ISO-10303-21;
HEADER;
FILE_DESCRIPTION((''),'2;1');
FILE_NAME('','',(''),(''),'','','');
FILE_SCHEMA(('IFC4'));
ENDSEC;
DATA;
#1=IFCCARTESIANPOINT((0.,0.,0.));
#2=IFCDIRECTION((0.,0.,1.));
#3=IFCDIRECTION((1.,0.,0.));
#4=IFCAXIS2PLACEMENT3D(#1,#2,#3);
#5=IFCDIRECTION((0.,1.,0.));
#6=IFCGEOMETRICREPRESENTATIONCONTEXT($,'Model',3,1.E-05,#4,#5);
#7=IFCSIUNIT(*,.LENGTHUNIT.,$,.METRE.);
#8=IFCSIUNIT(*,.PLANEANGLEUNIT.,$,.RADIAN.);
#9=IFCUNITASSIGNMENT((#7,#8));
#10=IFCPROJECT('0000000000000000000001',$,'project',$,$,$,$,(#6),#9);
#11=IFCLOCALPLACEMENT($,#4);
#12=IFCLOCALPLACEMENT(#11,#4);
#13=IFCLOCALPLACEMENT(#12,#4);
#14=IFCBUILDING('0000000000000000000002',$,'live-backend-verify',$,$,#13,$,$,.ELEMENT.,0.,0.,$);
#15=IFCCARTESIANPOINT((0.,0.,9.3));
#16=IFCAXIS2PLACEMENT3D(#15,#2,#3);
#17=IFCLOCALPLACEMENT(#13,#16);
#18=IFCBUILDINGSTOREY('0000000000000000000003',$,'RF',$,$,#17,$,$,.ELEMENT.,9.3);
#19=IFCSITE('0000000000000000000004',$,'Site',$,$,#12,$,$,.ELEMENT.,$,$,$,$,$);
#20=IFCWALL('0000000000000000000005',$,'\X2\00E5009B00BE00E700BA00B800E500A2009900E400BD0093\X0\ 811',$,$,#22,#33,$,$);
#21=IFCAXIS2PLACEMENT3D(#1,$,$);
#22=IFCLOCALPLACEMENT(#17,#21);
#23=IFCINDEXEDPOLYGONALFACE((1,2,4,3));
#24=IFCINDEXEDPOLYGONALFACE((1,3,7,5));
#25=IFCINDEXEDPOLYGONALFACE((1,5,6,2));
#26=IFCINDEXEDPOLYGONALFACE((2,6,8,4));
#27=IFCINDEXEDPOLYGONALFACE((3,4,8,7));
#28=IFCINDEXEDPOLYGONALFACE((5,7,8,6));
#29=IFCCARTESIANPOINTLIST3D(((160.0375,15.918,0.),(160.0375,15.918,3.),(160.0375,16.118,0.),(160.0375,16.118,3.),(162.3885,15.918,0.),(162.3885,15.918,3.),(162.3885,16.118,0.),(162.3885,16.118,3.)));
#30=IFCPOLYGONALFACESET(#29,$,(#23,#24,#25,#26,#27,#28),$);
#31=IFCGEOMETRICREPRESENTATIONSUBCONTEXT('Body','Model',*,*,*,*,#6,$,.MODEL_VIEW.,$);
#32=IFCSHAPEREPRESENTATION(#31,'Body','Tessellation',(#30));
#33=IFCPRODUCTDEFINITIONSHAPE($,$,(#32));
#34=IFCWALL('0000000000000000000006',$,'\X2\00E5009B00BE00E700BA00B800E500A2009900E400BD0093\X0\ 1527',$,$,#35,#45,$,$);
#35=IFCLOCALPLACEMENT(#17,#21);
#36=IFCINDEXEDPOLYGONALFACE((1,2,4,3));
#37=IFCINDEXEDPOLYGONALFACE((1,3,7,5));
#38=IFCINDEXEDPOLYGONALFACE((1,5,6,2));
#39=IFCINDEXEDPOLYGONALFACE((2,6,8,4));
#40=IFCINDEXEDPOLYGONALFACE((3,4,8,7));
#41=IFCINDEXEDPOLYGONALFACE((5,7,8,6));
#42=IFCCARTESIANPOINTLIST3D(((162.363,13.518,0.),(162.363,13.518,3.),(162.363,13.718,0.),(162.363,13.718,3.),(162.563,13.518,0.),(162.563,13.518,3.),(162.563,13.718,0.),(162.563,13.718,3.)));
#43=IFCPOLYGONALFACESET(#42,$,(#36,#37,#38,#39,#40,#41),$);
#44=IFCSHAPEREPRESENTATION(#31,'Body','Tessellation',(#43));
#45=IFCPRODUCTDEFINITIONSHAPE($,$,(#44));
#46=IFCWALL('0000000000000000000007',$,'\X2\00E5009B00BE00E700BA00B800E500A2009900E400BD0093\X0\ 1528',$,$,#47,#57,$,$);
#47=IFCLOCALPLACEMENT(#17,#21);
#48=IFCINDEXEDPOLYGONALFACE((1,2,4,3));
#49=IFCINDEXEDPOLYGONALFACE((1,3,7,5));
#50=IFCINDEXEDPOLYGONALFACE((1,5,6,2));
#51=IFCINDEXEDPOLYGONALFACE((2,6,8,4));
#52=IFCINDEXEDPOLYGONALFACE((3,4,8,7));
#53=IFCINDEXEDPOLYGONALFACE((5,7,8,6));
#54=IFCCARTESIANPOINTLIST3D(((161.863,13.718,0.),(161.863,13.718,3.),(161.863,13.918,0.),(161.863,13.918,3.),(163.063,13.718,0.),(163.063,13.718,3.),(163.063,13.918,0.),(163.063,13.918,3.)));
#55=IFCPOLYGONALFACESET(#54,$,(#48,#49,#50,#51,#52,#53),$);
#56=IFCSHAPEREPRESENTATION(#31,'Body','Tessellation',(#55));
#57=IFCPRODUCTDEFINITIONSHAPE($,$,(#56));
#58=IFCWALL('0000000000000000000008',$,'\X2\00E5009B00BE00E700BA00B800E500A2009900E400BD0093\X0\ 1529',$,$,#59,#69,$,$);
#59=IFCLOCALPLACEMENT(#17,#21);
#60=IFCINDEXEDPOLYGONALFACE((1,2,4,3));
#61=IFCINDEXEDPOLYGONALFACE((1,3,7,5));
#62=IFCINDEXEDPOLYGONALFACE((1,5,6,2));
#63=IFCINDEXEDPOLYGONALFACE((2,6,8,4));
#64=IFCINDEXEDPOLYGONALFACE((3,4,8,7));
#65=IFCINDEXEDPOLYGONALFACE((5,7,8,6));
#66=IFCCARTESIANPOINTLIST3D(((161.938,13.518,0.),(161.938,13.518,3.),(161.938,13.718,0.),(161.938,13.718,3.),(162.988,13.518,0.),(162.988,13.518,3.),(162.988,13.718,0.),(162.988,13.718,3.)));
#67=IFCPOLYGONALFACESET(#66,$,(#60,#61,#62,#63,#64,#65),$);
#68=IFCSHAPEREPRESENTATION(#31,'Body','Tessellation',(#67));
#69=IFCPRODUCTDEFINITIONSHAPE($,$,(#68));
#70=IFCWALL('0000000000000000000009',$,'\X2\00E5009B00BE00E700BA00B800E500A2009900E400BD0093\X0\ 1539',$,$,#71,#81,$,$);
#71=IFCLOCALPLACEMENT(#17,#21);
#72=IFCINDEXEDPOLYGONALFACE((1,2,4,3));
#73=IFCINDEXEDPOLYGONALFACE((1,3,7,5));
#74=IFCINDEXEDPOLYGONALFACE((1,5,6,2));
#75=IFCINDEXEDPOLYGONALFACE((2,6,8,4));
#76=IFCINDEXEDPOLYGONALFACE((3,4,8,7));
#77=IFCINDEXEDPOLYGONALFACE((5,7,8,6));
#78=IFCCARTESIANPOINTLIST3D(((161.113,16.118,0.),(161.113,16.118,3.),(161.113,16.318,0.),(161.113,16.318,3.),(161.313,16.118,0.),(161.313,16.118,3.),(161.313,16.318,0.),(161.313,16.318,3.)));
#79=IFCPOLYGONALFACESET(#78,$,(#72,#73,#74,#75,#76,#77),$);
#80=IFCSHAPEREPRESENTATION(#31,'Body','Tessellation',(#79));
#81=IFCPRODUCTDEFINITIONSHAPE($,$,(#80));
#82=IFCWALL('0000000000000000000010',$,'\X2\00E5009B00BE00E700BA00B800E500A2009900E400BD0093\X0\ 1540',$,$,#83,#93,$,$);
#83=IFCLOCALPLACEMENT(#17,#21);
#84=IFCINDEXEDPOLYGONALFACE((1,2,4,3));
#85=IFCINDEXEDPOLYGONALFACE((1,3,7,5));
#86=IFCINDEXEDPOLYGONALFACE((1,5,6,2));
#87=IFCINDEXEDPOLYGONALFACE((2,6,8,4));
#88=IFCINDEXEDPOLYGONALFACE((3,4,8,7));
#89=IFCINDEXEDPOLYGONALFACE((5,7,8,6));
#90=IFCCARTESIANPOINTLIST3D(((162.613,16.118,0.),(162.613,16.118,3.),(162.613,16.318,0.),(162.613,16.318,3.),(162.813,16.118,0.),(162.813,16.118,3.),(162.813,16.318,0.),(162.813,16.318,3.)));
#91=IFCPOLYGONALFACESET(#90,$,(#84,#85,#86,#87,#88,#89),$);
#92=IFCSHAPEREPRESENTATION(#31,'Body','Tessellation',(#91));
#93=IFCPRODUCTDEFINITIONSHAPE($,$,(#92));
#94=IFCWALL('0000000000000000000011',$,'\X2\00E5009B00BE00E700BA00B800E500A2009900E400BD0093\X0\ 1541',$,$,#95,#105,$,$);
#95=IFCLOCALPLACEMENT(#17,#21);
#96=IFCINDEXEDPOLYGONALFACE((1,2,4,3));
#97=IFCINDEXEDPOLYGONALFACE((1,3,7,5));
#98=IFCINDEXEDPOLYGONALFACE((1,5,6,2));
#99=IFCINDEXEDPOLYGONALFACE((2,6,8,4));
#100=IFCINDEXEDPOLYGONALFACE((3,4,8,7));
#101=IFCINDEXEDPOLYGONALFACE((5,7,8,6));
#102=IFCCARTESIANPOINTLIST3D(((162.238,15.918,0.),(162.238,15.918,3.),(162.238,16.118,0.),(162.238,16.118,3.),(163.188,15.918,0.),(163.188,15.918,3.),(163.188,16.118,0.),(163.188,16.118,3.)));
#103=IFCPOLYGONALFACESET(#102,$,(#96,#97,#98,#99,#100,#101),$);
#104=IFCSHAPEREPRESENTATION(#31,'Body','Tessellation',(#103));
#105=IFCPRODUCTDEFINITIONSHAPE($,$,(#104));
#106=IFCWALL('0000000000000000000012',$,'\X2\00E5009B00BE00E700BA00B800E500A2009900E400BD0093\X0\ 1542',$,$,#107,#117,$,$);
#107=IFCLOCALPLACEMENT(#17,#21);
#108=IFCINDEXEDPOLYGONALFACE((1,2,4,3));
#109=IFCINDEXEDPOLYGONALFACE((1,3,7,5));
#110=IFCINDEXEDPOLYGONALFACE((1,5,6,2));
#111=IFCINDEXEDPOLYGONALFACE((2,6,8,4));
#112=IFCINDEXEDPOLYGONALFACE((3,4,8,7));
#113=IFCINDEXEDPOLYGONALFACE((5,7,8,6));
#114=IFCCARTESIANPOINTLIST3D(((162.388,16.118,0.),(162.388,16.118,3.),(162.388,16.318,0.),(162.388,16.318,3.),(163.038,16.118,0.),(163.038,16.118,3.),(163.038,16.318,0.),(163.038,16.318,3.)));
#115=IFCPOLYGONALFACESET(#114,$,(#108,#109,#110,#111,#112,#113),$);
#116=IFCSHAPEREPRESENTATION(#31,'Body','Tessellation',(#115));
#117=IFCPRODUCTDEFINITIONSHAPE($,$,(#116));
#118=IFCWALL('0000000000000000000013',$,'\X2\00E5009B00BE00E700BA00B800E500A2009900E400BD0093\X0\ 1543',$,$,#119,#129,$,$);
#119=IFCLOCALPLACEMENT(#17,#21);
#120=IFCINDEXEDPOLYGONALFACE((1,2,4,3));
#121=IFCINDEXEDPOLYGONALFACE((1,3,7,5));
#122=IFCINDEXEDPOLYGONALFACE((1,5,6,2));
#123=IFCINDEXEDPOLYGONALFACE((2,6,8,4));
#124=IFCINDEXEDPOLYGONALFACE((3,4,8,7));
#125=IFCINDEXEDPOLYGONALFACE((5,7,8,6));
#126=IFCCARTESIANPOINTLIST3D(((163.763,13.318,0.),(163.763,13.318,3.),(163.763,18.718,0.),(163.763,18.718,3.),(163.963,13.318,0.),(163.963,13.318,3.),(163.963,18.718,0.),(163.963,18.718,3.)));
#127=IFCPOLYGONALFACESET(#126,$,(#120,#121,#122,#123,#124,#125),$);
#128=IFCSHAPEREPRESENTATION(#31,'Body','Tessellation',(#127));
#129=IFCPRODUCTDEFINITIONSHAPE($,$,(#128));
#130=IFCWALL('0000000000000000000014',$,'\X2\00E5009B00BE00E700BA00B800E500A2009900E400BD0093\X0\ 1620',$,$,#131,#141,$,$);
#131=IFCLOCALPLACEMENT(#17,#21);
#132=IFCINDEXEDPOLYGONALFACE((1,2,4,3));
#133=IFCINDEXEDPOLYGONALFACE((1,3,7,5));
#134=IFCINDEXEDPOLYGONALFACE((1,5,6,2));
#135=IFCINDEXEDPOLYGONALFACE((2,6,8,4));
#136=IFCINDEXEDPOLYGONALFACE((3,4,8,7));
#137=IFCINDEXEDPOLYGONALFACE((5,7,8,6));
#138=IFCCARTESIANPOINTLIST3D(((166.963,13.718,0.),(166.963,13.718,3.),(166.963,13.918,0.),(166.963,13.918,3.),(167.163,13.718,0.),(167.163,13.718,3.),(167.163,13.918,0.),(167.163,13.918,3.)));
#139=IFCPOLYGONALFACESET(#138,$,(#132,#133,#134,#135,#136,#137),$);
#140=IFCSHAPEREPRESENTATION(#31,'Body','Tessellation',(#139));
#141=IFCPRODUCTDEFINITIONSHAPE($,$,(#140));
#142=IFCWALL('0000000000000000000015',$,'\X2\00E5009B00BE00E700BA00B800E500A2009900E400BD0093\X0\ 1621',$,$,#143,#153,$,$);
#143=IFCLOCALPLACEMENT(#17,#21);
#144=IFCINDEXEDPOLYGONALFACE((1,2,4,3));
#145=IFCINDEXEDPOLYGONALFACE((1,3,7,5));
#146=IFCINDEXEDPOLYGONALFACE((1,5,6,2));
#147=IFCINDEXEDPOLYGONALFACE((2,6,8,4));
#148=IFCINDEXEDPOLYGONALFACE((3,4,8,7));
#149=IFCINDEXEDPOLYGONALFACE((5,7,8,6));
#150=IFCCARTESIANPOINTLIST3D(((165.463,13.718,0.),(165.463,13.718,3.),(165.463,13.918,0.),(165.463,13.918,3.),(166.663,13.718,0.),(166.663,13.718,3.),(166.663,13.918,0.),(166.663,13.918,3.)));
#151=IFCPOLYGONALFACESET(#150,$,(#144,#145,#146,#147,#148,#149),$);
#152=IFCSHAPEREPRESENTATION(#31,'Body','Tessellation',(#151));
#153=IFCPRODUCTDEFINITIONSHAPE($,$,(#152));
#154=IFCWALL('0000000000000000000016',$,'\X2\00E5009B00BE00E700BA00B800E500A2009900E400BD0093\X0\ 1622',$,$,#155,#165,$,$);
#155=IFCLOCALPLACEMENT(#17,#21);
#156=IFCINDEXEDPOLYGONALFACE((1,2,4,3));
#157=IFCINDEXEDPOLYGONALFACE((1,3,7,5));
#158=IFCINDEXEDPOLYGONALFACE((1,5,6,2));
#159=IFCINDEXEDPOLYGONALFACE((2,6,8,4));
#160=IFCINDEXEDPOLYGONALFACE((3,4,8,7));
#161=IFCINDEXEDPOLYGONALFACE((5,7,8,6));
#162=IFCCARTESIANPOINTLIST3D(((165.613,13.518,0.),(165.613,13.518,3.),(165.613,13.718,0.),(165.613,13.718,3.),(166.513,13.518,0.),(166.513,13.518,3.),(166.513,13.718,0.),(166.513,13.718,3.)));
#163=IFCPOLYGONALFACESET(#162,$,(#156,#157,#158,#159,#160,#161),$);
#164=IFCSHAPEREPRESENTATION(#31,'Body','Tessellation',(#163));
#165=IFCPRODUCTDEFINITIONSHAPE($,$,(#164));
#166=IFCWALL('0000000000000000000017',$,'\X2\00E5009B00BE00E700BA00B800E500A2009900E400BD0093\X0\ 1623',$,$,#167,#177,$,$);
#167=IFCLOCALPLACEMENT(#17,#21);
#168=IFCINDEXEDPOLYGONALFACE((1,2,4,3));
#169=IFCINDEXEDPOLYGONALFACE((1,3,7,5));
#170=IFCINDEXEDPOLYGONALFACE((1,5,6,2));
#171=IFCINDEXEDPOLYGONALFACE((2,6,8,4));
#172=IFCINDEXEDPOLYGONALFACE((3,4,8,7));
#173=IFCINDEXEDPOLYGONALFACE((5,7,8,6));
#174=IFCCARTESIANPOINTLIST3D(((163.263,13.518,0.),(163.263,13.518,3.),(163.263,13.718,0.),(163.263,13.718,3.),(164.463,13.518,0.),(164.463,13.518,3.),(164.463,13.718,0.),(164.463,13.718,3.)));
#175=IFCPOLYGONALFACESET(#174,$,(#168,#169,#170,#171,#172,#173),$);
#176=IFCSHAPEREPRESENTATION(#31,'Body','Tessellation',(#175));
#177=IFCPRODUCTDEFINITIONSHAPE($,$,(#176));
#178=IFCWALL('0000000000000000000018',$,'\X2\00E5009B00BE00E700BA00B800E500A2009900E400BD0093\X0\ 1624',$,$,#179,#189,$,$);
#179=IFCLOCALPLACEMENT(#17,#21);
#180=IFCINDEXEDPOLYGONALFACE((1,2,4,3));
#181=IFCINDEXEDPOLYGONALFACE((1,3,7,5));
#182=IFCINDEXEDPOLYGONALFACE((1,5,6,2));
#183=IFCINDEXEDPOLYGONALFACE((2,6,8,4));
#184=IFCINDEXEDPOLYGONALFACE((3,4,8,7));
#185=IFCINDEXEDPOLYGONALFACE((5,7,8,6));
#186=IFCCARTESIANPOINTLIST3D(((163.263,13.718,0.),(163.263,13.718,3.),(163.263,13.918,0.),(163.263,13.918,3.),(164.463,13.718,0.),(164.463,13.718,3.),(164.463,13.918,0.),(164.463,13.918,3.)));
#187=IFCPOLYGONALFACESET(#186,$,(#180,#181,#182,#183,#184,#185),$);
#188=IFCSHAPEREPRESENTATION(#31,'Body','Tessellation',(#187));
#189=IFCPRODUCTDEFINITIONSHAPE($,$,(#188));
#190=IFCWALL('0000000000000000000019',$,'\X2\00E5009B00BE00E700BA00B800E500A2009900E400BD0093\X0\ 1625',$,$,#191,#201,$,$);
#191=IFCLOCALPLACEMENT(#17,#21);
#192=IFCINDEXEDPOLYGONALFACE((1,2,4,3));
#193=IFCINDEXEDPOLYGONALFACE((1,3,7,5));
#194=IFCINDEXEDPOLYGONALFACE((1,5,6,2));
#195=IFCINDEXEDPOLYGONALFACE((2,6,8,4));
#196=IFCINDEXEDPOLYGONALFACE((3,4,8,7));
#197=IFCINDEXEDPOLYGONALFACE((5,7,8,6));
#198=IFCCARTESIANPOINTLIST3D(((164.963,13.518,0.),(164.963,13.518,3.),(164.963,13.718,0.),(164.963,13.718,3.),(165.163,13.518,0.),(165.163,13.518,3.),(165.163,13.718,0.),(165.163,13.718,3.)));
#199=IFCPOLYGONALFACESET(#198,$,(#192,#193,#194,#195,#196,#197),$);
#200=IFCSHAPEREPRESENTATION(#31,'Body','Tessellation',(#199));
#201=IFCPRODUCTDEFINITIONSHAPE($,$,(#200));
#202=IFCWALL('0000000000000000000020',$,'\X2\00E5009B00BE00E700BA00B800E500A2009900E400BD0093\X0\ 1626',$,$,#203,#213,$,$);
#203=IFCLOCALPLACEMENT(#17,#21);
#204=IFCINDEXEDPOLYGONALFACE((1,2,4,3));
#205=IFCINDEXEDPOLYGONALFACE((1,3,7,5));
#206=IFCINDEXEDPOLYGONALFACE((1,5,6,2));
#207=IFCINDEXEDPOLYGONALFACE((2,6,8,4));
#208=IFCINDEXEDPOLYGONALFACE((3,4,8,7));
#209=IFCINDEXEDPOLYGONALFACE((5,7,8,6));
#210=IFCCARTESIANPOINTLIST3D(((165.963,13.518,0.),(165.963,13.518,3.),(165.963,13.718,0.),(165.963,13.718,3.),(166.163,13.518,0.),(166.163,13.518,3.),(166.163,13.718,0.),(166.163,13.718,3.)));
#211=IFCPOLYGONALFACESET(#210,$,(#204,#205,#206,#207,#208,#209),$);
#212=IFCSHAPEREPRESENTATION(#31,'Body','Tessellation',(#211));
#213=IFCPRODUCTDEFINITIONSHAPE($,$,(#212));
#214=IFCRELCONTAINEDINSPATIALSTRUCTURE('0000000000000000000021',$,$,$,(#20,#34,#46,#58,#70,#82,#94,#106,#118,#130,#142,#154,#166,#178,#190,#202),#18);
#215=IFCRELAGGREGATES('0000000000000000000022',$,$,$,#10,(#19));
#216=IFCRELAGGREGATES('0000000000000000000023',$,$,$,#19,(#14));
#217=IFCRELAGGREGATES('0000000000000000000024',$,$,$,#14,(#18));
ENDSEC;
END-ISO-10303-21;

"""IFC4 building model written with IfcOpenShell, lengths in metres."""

from ifc_helpers import new_model, si_unit, direction, frame, frame_2d, origin_with_axes, place, context, subcontext, project, spatial, rectangle, extrude, element, save


model = new_model("IFC4")

# Units and contexts
model_context = context("Model", 3, precision=1e-05, world=origin_with_axes(), true_north=direction((0.0, 1.0, 0.0)))
body_context = subcontext(model_context, "Body", "Model", "MODEL_VIEW")
ifc_project = project(units=[si_unit("LENGTHUNIT", "METRE"), si_unit("PLANEANGLEUNIT", "RADIAN")], contexts=[model_context])

# Site, building, storey
placement = place(None, origin_with_axes())
site_placement = place(placement, origin_with_axes())
site = spatial("IfcSite", under=ifc_project, at=site_placement, Name="Site", CompositionType="ELEMENT")
building_placement = place(site_placement, origin_with_axes())
building = spatial("IfcBuilding", under=site, at=building_placement, Name="live-backend-verify", CompositionType="ELEMENT", ElevationOfRefHeight=0.0, ElevationOfTerrain=0.0)
storey_placement = place(building_placement, frame((0.0, 0.0, 9.3), z_axis=(0.0, 0.0, 1.0), x_axis=(1.0, 0.0, 0.0)))
storey = spatial("IfcBuildingStorey", under=building, at=storey_placement, Name="RF", CompositionType="ELEMENT", Elevation=9.3)

# Walls
wall_1_placement = place(storey_placement, frame((161.213, 16.018, 0.0), z_axis=(0.0, 0.0, 1.0), x_axis=(-1.0, 0.0, 0.0)))
element("IfcWall", 1, at=wall_1_placement, inside=storey, Name="å\u009b¾çº¸å¢\u0099ä½\u0093 811", context=body_context, shape_type="SweptSolid", body=[
    extrude(rectangle(XDim=2.351, YDim=0.2, at=frame_2d((0.0, 0.0), x_axis=(1.0, 0.0, 0.0))), frame((0.0, 0.0, 0.0), z_axis=(0.0, 0.0, 1.0)), (0.0, 0.0, 1.0), 3.0),
])
wall_2_placement = place(storey_placement, frame((162.463, 13.618, 0.0), z_axis=(0.0, 0.0, 1.0), x_axis=(0.0, 1.0, 0.0)))
element("IfcWall", 2, at=wall_2_placement, inside=storey, Name="å\u009b¾çº¸å¢\u0099ä½\u0093 1527", context=body_context, shape_type="SweptSolid", body=[
    extrude(rectangle(XDim=0.2, YDim=0.2, at=frame_2d((0.0, 0.0), x_axis=(1.0, 0.0, 0.0))), frame((0.0, 0.0, 0.0), z_axis=(0.0, 0.0, 1.0)), (0.0, 0.0, 1.0), 3.0),
])
wall_3_placement = place(storey_placement, frame((162.463, 13.818, 0.0), z_axis=(0.0, 0.0, 1.0), x_axis=(1.0, 0.0, 0.0)))
element("IfcWall", 3, at=wall_3_placement, inside=storey, Name="å\u009b¾çº¸å¢\u0099ä½\u0093 1528", context=body_context, shape_type="SweptSolid", body=[
    extrude(rectangle(XDim=1.2, YDim=0.2, at=frame_2d((0.0, 0.0), x_axis=(1.0, 0.0, 0.0))), frame((0.0, 0.0, 0.0), z_axis=(0.0, 0.0, 1.0)), (0.0, 0.0, 1.0), 3.0),
])
wall_4_placement = place(storey_placement, frame((162.463, 13.618, 0.0), z_axis=(0.0, 0.0, 1.0), x_axis=(1.0, 0.0, 0.0)))
element("IfcWall", 4, at=wall_4_placement, inside=storey, Name="å\u009b¾çº¸å¢\u0099ä½\u0093 1529", context=body_context, shape_type="SweptSolid", body=[
    extrude(rectangle(XDim=1.05, YDim=0.2, at=frame_2d((0.0, 0.0), x_axis=(1.0, 0.0, 0.0))), frame((0.0, 0.0, 0.0), z_axis=(0.0, 0.0, 1.0)), (0.0, 0.0, 1.0), 3.0),
])
for number, where, z_axis, x_axis, name in (
    (5, (161.213, 16.218, 0.0), (0.0, 0.0, 1.0), (0.0, -1.0, 0.0), "å\u009b¾çº¸å¢\u0099ä½\u0093 1539"),
    (6, (162.713, 16.218, 0.0), (0.0, 0.0, 1.0), (0.0, -1.0, 0.0), "å\u009b¾çº¸å¢\u0099ä½\u0093 1540"),
):
    element("IfcWall", number, at=place(storey_placement, frame(where, z_axis=z_axis, x_axis=x_axis)), inside=storey, Name=name, context=body_context, shape_type="SweptSolid", body=[
        extrude(rectangle(XDim=0.2, YDim=0.2, at=frame_2d((0.0, 0.0), x_axis=(1.0, 0.0, 0.0))), frame((0.0, 0.0, 0.0), z_axis=(0.0, 0.0, 1.0)), (0.0, 0.0, 1.0), 3.0),
    ])
wall_5_placement = place(storey_placement, frame((162.713, 16.018, 0.0), z_axis=(0.0, 0.0, 1.0), x_axis=(1.0, 0.0, 0.0)))
element("IfcWall", 7, at=wall_5_placement, inside=storey, Name="å\u009b¾çº¸å¢\u0099ä½\u0093 1541", context=body_context, shape_type="SweptSolid", body=[
    extrude(rectangle(XDim=0.95, YDim=0.2, at=frame_2d((0.0, 0.0), x_axis=(1.0, 0.0, 0.0))), frame((0.0, 0.0, 0.0), z_axis=(0.0, 0.0, 1.0)), (0.0, 0.0, 1.0), 3.0),
])
wall_6_placement = place(storey_placement, frame((162.713, 16.218, 0.0), z_axis=(0.0, 0.0, 1.0), x_axis=(1.0, 0.0, 0.0)))
element("IfcWall", 8, at=wall_6_placement, inside=storey, Name="å\u009b¾çº¸å¢\u0099ä½\u0093 1542", context=body_context, shape_type="SweptSolid", body=[
    extrude(rectangle(XDim=0.65, YDim=0.2, at=frame_2d((0.0, 0.0), x_axis=(1.0, 0.0, 0.0))), frame((0.0, 0.0, 0.0), z_axis=(0.0, 0.0, 1.0)), (0.0, 0.0, 1.0), 3.0),
])
wall_7_placement = place(storey_placement, frame((163.863, 16.018, 0.0), z_axis=(0.0, 0.0, 1.0), x_axis=(0.0, 1.0, 0.0)))
element("IfcWall", 9, at=wall_7_placement, inside=storey, Name="å\u009b¾çº¸å¢\u0099ä½\u0093 1543", context=body_context, shape_type="SweptSolid", body=[
    extrude(rectangle(XDim=5.4, YDim=0.2, at=frame_2d((0.0, 0.0), x_axis=(1.0, 0.0, 0.0))), frame((0.0, 0.0, 0.0), z_axis=(0.0, 0.0, 1.0)), (0.0, 0.0, 1.0), 3.0),
])
wall_8_placement = place(storey_placement, frame((167.063, 13.818, 0.0), z_axis=(0.0, 0.0, 1.0), x_axis=(-1.0, 0.0, 0.0)))
element("IfcWall", 10, at=wall_8_placement, inside=storey, Name="å\u009b¾çº¸å¢\u0099ä½\u0093 1620", context=body_context, shape_type="SweptSolid", body=[
    extrude(rectangle(XDim=0.2, YDim=0.2, at=frame_2d((0.0, 0.0), x_axis=(1.0, 0.0, 0.0))), frame((0.0, 0.0, 0.0), z_axis=(0.0, 0.0, 1.0)), (0.0, 0.0, 1.0), 3.0),
])
wall_9_placement = place(storey_placement, frame((166.063, 13.818, 0.0), z_axis=(0.0, 0.0, 1.0), x_axis=(1.0, 0.0, 0.0)))
element("IfcWall", 11, at=wall_9_placement, inside=storey, Name="å\u009b¾çº¸å¢\u0099ä½\u0093 1621", context=body_context, shape_type="SweptSolid", body=[
    extrude(rectangle(XDim=1.2, YDim=0.2, at=frame_2d((0.0, 0.0), x_axis=(1.0, 0.0, 0.0))), frame((0.0, 0.0, 0.0), z_axis=(0.0, 0.0, 1.0)), (0.0, 0.0, 1.0), 3.0),
])
wall_10_placement = place(storey_placement, frame((166.063, 13.618, 0.0), z_axis=(0.0, 0.0, 1.0), x_axis=(1.0, 0.0, 0.0)))
element("IfcWall", 12, at=wall_10_placement, inside=storey, Name="å\u009b¾çº¸å¢\u0099ä½\u0093 1622", context=body_context, shape_type="SweptSolid", body=[
    extrude(rectangle(XDim=0.9, YDim=0.2, at=frame_2d((0.0, 0.0), x_axis=(1.0, 0.0, 0.0))), frame((0.0, 0.0, 0.0), z_axis=(0.0, 0.0, 1.0)), (0.0, 0.0, 1.0), 3.0),
])
for number, where, z_axis, x_axis, name in (
    (13, (163.863, 13.618, 0.0), (0.0, 0.0, 1.0), (1.0, 0.0, 0.0), "å\u009b¾çº¸å¢\u0099ä½\u0093 1623"),
    (14, (163.863, 13.818, 0.0), (0.0, 0.0, 1.0), (1.0, 0.0, 0.0), "å\u009b¾çº¸å¢\u0099ä½\u0093 1624"),
):
    element("IfcWall", number, at=place(storey_placement, frame(where, z_axis=z_axis, x_axis=x_axis)), inside=storey, Name=name, context=body_context, shape_type="SweptSolid", body=[
        extrude(rectangle(XDim=1.2, YDim=0.2, at=frame_2d((0.0, 0.0), x_axis=(1.0, 0.0, 0.0))), frame((0.0, 0.0, 0.0), z_axis=(0.0, 0.0, 1.0)), (0.0, 0.0, 1.0), 3.0),
    ])
for number, where, z_axis, x_axis, name in (
    (15, (165.063, 13.618, 0.0), (0.0, 0.0, 1.0), (0.0, 1.0, 0.0), "å\u009b¾çº¸å¢\u0099ä½\u0093 1625"),
    (16, (166.063, 13.618, 0.0), (0.0, 0.0, 1.0), (0.0, 1.0, 0.0), "å\u009b¾çº¸å¢\u0099ä½\u0093 1626"),
):
    element("IfcWall", number, at=place(storey_placement, frame(where, z_axis=z_axis, x_axis=x_axis)), inside=storey, Name=name, context=body_context, shape_type="SweptSolid", body=[
        extrude(rectangle(XDim=0.2, YDim=0.2, at=frame_2d((0.0, 0.0), x_axis=(1.0, 0.0, 0.0))), frame((0.0, 0.0, 0.0), z_axis=(0.0, 0.0, 1.0)), (0.0, 0.0, 1.0), 3.0),
    ])

save(model, "model.ifc")
